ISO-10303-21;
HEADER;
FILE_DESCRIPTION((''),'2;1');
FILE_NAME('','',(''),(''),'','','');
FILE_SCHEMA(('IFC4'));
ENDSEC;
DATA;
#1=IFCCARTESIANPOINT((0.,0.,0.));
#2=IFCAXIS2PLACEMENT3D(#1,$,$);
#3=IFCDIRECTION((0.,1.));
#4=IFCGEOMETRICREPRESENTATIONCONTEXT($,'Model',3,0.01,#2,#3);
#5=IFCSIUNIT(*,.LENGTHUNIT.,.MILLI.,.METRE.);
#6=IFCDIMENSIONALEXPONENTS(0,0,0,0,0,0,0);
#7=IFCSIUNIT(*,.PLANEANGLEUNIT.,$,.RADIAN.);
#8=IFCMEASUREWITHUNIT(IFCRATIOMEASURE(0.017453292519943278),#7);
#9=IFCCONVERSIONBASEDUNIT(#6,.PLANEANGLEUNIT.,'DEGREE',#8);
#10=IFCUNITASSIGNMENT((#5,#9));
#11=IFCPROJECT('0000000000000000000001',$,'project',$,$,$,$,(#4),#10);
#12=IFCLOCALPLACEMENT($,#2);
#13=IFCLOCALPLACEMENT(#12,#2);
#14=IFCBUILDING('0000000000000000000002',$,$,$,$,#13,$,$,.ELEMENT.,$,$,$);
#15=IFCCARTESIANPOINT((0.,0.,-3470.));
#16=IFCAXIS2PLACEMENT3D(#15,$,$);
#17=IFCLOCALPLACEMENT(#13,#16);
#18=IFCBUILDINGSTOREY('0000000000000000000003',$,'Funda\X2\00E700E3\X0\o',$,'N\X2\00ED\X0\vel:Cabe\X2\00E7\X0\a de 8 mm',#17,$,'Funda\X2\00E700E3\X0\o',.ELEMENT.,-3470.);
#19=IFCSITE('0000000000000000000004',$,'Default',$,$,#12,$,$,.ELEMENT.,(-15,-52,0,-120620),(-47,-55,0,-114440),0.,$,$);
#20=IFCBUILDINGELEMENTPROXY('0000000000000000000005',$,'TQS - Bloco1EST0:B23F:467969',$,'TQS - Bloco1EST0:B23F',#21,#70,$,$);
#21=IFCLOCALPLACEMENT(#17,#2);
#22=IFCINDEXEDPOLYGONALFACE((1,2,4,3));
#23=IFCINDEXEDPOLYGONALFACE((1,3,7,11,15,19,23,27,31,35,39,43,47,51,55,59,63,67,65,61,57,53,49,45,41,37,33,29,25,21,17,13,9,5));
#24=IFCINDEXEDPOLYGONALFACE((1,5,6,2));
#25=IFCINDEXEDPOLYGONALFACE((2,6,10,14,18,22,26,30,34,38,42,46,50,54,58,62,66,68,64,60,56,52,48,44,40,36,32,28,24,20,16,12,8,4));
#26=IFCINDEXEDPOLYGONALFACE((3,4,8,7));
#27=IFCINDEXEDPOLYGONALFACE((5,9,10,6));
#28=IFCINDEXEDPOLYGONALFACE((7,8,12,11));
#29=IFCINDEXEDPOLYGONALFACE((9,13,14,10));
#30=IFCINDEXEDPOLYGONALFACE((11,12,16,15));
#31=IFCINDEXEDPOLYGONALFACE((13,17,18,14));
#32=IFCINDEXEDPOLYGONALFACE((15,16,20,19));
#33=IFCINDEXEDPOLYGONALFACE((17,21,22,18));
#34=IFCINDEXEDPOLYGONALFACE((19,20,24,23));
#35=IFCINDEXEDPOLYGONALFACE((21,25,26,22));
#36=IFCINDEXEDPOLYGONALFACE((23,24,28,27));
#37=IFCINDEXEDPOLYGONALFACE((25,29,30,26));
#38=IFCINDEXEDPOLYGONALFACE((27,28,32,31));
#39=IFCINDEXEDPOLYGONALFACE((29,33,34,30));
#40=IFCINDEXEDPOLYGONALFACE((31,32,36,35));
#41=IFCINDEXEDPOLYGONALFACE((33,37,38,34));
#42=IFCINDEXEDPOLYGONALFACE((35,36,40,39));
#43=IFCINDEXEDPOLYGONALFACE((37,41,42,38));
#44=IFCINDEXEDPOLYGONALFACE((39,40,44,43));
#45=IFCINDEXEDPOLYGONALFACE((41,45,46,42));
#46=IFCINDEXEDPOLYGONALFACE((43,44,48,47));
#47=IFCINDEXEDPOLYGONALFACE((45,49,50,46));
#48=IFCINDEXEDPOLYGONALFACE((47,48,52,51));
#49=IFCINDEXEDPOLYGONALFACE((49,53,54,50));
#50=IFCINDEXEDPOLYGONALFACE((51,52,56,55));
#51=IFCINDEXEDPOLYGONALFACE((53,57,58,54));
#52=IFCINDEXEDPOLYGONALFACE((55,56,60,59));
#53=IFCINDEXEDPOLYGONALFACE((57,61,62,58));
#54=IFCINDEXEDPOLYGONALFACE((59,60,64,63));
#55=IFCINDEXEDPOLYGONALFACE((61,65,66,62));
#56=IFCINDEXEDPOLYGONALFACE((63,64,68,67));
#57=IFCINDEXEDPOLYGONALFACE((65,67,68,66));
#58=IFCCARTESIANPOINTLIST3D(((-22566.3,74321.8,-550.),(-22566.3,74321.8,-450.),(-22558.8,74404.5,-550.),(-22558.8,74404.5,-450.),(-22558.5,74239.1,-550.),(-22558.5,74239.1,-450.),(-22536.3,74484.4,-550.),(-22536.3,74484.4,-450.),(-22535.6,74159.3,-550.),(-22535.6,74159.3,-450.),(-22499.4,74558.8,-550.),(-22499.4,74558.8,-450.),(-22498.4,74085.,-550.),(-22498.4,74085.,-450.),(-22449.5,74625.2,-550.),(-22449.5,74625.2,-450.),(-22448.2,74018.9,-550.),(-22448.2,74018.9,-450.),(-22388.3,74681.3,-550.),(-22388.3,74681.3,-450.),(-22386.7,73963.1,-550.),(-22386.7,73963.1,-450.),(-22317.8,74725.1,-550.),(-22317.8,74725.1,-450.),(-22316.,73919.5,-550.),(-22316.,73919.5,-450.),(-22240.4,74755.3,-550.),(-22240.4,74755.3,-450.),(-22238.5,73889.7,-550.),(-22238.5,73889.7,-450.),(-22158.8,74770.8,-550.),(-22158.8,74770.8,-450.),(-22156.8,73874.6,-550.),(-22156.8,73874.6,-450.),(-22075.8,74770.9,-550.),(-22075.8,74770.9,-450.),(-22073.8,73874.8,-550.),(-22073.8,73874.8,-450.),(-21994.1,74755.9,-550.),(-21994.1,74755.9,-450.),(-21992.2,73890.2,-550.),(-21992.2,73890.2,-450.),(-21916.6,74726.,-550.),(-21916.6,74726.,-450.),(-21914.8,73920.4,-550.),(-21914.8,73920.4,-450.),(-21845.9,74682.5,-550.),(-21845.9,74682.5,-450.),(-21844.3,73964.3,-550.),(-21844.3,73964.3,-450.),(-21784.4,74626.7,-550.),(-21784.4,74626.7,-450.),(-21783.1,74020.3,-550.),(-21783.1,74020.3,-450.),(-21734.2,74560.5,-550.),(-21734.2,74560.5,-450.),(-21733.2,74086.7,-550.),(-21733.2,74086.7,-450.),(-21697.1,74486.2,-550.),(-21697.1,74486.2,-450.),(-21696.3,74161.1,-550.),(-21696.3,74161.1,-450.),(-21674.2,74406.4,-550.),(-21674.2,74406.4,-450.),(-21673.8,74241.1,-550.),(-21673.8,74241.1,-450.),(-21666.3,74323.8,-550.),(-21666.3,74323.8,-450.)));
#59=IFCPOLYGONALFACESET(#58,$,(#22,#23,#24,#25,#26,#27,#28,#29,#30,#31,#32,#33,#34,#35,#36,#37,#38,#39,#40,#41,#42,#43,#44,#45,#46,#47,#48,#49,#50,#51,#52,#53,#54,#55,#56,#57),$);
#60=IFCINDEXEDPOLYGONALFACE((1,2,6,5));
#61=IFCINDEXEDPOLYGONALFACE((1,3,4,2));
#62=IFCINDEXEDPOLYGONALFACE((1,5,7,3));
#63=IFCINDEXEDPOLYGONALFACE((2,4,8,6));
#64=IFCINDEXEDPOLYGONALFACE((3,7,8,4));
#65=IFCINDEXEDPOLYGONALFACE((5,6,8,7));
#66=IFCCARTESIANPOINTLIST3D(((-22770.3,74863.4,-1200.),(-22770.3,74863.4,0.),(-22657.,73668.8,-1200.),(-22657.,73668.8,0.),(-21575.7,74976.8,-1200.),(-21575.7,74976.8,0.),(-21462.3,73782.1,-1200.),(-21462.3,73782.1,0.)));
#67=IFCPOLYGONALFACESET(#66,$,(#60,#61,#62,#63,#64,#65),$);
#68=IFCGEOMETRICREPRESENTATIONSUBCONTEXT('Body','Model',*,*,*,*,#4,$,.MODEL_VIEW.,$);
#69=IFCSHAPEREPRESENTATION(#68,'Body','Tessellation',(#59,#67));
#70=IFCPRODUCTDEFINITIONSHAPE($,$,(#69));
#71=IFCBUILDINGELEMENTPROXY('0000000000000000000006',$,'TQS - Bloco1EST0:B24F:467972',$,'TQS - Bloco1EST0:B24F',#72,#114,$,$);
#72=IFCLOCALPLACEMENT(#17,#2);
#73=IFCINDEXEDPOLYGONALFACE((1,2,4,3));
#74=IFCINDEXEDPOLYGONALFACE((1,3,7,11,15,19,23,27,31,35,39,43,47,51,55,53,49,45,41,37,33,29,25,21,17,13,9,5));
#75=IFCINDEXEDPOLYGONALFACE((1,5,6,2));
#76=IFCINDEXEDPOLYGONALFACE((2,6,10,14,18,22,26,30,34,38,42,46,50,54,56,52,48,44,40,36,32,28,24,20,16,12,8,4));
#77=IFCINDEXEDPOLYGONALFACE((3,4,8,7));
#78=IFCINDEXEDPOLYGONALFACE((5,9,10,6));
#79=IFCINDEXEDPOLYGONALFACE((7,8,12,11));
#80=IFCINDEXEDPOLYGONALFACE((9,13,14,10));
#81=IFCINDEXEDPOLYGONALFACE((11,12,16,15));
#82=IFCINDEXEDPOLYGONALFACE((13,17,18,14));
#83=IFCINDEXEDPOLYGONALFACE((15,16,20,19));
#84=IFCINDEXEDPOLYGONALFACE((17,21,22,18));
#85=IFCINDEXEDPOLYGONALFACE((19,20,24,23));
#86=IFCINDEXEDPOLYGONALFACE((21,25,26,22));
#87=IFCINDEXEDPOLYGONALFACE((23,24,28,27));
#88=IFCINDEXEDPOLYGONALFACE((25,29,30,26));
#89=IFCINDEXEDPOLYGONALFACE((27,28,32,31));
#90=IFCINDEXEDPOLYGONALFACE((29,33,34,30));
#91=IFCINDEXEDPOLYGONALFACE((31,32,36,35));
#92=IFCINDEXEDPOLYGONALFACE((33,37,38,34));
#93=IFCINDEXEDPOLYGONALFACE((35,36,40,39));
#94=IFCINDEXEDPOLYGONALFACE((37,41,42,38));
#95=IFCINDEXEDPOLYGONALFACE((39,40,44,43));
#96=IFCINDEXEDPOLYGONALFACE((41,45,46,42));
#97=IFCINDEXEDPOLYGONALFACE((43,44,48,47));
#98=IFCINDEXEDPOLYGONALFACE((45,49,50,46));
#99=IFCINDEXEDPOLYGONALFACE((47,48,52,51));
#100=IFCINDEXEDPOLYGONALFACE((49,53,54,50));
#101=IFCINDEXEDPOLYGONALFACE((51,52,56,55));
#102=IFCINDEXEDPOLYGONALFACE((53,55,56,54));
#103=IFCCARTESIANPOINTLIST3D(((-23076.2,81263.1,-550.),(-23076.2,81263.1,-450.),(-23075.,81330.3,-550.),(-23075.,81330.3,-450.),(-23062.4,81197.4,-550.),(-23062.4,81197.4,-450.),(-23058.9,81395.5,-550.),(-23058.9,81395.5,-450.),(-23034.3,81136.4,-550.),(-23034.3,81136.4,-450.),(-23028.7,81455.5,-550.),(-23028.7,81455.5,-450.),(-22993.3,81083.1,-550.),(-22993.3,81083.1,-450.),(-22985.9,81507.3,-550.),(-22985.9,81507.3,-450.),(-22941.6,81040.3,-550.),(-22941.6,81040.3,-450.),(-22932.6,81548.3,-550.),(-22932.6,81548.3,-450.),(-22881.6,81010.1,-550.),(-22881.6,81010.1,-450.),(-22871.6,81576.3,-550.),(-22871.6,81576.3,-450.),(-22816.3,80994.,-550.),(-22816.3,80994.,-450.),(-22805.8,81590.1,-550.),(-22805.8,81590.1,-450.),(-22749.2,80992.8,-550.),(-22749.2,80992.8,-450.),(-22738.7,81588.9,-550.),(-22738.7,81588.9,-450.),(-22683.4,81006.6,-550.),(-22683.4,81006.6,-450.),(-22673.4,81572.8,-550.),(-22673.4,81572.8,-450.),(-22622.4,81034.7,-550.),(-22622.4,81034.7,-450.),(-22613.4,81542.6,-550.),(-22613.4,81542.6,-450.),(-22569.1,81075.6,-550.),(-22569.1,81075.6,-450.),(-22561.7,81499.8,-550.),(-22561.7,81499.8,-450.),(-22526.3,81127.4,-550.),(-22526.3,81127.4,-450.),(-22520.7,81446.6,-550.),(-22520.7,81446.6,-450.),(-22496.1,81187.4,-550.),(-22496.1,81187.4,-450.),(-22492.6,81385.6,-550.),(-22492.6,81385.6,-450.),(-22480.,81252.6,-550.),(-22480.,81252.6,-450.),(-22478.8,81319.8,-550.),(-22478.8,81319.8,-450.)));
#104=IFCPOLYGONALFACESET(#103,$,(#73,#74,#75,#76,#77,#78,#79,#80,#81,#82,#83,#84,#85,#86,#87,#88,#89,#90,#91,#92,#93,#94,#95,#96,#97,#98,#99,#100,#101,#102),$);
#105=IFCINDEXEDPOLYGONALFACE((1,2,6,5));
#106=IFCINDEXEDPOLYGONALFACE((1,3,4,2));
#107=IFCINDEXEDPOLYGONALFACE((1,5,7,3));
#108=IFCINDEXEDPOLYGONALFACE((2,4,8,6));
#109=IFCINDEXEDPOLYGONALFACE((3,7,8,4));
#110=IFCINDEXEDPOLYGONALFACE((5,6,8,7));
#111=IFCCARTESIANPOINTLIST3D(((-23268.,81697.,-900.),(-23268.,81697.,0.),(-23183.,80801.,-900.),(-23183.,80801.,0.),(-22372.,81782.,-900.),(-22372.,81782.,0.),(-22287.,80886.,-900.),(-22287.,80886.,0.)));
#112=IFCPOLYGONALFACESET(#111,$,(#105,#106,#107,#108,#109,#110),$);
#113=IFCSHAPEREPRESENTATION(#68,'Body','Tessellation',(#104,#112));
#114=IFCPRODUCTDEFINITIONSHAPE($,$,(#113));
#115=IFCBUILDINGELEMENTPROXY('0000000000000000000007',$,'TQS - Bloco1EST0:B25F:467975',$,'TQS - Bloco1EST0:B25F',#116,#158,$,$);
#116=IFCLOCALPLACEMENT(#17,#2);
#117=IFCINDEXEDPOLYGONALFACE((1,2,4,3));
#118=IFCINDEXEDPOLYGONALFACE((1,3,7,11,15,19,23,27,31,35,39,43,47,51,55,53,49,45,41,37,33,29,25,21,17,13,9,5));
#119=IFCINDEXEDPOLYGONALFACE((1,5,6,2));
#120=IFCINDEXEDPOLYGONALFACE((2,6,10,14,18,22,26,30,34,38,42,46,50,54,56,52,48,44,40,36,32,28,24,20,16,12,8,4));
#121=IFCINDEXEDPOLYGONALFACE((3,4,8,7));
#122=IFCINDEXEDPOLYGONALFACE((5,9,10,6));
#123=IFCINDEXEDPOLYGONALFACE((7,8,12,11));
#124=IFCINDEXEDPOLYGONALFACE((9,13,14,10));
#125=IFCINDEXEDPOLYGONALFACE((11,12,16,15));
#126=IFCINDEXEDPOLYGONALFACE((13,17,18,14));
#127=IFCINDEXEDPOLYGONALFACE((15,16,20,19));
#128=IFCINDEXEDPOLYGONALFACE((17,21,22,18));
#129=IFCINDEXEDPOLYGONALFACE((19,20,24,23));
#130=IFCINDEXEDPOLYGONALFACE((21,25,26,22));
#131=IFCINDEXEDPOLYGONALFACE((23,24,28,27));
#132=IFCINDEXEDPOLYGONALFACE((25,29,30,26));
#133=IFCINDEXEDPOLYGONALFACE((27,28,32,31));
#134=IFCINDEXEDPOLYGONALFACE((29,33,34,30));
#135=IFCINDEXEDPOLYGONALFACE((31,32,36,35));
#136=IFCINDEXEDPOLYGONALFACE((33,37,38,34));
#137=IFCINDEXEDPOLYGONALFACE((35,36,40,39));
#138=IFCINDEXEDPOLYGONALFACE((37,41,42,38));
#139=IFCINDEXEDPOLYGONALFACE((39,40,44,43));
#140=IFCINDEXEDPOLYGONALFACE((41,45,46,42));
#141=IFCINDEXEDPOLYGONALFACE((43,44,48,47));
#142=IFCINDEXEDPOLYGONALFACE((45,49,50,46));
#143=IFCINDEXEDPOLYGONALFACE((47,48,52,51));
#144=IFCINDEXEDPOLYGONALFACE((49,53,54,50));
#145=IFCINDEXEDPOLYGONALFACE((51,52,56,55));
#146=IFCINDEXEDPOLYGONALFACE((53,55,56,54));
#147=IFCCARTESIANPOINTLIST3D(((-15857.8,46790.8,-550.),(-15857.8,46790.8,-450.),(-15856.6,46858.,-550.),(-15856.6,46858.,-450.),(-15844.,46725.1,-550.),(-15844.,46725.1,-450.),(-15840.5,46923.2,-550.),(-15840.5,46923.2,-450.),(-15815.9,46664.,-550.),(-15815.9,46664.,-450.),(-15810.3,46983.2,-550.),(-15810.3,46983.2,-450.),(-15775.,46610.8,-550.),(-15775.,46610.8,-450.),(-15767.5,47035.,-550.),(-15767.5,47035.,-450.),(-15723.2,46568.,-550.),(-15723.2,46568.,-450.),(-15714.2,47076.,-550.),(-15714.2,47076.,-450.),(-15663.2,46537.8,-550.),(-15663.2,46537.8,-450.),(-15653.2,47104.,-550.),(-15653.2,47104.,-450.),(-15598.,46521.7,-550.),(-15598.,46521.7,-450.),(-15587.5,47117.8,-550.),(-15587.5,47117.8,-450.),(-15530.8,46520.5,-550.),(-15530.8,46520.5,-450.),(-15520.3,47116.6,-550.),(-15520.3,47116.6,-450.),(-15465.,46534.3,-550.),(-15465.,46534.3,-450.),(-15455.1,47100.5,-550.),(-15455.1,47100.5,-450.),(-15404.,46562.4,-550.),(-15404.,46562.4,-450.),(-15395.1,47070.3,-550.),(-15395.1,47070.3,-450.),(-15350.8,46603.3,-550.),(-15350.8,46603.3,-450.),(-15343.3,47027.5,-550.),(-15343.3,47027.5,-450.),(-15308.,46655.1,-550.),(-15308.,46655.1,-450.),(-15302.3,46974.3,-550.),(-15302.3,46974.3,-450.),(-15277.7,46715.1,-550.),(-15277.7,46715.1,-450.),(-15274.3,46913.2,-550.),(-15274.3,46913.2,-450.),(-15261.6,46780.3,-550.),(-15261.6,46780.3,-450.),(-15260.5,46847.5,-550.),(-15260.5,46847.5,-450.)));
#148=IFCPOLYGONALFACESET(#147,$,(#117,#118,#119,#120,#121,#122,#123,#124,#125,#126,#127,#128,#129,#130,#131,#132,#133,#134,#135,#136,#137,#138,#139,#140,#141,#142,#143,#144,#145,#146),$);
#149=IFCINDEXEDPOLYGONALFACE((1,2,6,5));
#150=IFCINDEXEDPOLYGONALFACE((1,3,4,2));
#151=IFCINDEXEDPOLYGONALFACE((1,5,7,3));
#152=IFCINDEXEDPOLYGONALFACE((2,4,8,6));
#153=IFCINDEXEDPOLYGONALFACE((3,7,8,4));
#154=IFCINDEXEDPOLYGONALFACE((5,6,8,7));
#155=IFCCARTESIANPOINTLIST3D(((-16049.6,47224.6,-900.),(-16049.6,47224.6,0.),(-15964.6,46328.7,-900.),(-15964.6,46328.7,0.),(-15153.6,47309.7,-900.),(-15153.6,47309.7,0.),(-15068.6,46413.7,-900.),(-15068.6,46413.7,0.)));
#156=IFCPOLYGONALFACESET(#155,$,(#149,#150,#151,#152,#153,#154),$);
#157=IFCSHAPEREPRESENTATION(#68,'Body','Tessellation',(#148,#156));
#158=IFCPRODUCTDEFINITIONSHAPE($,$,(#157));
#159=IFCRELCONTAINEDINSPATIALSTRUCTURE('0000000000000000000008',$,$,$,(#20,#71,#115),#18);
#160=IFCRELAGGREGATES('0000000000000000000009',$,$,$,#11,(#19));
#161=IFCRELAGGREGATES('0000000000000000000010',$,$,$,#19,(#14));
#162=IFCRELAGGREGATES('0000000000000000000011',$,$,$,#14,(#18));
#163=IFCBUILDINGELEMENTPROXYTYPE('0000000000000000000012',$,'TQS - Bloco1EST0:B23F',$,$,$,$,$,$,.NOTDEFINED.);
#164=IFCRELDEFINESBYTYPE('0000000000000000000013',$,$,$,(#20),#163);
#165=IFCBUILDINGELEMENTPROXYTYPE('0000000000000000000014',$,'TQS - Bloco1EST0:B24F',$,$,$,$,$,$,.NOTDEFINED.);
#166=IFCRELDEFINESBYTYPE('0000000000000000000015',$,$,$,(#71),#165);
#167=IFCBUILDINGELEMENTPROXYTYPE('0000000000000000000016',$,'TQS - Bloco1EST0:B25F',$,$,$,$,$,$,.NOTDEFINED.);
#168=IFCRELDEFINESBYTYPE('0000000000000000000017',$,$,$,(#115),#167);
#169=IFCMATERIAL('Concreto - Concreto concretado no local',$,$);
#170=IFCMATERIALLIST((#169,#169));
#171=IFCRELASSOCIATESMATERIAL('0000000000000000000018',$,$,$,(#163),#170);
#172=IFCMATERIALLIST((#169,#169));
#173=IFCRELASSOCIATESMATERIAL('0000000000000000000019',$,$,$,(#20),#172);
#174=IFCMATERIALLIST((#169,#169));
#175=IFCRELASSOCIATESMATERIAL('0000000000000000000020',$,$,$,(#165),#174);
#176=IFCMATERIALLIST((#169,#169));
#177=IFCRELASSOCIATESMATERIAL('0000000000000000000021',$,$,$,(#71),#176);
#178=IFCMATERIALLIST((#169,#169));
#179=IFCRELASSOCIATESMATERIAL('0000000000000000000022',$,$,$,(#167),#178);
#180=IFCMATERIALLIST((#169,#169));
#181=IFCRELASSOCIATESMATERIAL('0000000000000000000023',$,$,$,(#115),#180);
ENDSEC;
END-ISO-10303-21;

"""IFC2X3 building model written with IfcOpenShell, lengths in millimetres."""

from ifc_helpers import new_model, entity, si_unit, converted_unit, direction, frame, frame_2d, origin, origin_2d_with_axis, place, context, subcontext, project, spatial, rectangle, circle, extrude, source, transform, mapped, material, material_list, type_object, type_shapes, element, save


model = new_model("IFC2X3")

# Units and contexts
model_context = context("Model", 3, precision=0.01, world=origin(), true_north=direction((0.0, 1.0)))
body_context = subcontext(model_context, "Body", "Model", "MODEL_VIEW")
ifc_project = project(units=[si_unit("LENGTHUNIT", "METRE", prefix="MILLI"), converted_unit("PLANEANGLEUNIT", "DEGREE", entity("IfcRatioMeasure", 0.017453292519943278), si_unit("PLANEANGLEUNIT", "RADIAN"), dimensions=[0, 0, 0, 0, 0, 0, 0])], contexts=[model_context])

# Site, building, storey
site_placement = place(None, origin())
site = spatial("IfcSite", under=ifc_project, at=site_placement, Name="Default", CompositionType="ELEMENT", RefLatitude=(-15, -52, 0, -120620), RefLongitude=(-47, -55, 0, -114440), RefElevation=0.0)
building_placement = place(site_placement, origin())
building = spatial("IfcBuilding", under=site, at=building_placement, CompositionType="ELEMENT")
storey_placement = place(building_placement, frame((0.0, 0.0, -3470.0)))
storey = spatial("IfcBuildingStorey", under=building, at=storey_placement, Name="Fundação", ObjectType="Nível:Cabeça de 8 mm", LongName="Fundação", CompositionType="ELEMENT", Elevation=-3470.0)

# Building element proxies
ifc_material_1 = material(Name="Concreto - Concreto concretado no local")
ifc_material_list_1 = material_list([ifc_material_1, ifc_material_1])
ifc_material_list_2 = material_list([ifc_material_1, ifc_material_1])
building_element_proxy_type_1 = type_object("IfcBuildingElementProxyType", Name="TQS - Bloco1EST0:B23F", PredefinedType="NOTDEFINED", material=ifc_material_list_2)
shared_shape_1 = source(origin(), body_context, "Body", "SweptSolid", [
    extrude(circle(Radius=450.0, at=frame_2d((0.0, 0.0), x_axis=(1.0, 0.0))), frame((0.0, 0.0, -550.0)), (0.0, 0.0, 1.0), 100.0),
    extrude(rectangle(XDim=1200.0, YDim=1200.0, at=origin_2d_with_axis()), frame((0.0, 0.0, -1200.0), z_axis=(0.0, 0.0, 1.0), x_axis=(-1.0, 0.0, 0.0)), (0.0, 0.0, 1.0), 1200.0),
])
type_shapes(building_element_proxy_type_1, [shared_shape_1])
proxy_1_placement = place(storey_placement, frame((-22116.3, 74322.8, 0.0), z_axis=(0.0, 0.0, 1.0), x_axis=(-0.094456, 0.995529, 0.0)))
element("IfcBuildingElementProxy", 1, at=proxy_1_placement, inside=storey, type_object=building_element_proxy_type_1, material=ifc_material_list_1, Name="TQS - Bloco1EST0:B23F:467969", ObjectType="TQS - Bloco1EST0:B23F", context=body_context, shape_type="MappedRepresentation", body=[
    mapped(shared_shape_1, transform((0.0, 0.0, 0.0), scale=1.0)),
])
ifc_material_list_3 = material_list([ifc_material_1, ifc_material_1])
ifc_material_list_4 = material_list([ifc_material_1, ifc_material_1])
building_element_proxy_type_2 = type_object("IfcBuildingElementProxyType", Name="TQS - Bloco1EST0:B24F", PredefinedType="NOTDEFINED", material=ifc_material_list_4)
shared_shape_2 = source(origin(), body_context, "Body", "SweptSolid", [
    extrude(circle(Radius=300.0, at=frame_2d((0.0, 0.0), x_axis=(1.0, 0.0))), frame((0.0, 0.0, -550.0)), (0.0, 0.0, 1.0), 100.0),
    extrude(rectangle(XDim=900.0, YDim=900.0, at=origin_2d_with_axis()), frame((0.0, 0.0, -900.0), z_axis=(0.0, 0.0, 1.0), x_axis=(-1.0, 0.0, 0.0)), (0.0, 0.0, 1.0), 900.0),
])
type_shapes(building_element_proxy_type_2, [shared_shape_2])
proxy_2_placement = place(storey_placement, frame((-22777.5, 81291.5, 0.0), z_axis=(0.0, 0.0, 1.0), x_axis=(-0.094456, 0.995529, 0.0)))
element("IfcBuildingElementProxy", 2, at=proxy_2_placement, inside=storey, type_object=building_element_proxy_type_2, material=ifc_material_list_3, Name="TQS - Bloco1EST0:B24F:467972", ObjectType="TQS - Bloco1EST0:B24F", context=body_context, shape_type="MappedRepresentation", body=[
    mapped(shared_shape_2, transform((0.0, 0.0, 0.0), scale=1.0)),
])
ifc_material_list_5 = material_list([ifc_material_1, ifc_material_1])
ifc_material_list_6 = material_list([ifc_material_1, ifc_material_1])
building_element_proxy_type_3 = type_object("IfcBuildingElementProxyType", Name="TQS - Bloco1EST0:B25F", PredefinedType="NOTDEFINED", material=ifc_material_list_6)
shared_shape_3 = source(origin(), body_context, "Body", "SweptSolid", [
    extrude(circle(Radius=300.0, at=frame_2d((0.0, 0.0), x_axis=(1.0, 0.0))), frame((0.0, 0.0, -550.0)), (0.0, 0.0, 1.0), 100.0),
    extrude(rectangle(XDim=900.0, YDim=900.0, at=origin_2d_with_axis()), frame((0.0, 0.0, -900.0), z_axis=(0.0, 0.0, 1.0), x_axis=(-1.0, 0.0, 0.0)), (0.0, 0.0, 1.0), 900.0),
])
type_shapes(building_element_proxy_type_3, [shared_shape_3])
proxy_3_placement = place(storey_placement, frame((-15559.1, 46819.2, 0.0), z_axis=(0.0, 0.0, 1.0), x_axis=(-0.094456, 0.995529, 0.0)))
element("IfcBuildingElementProxy", 3, at=proxy_3_placement, inside=storey, type_object=building_element_proxy_type_3, material=ifc_material_list_5, Name="TQS - Bloco1EST0:B25F:467975", ObjectType="TQS - Bloco1EST0:B25F", context=body_context, shape_type="MappedRepresentation", body=[
    mapped(shared_shape_3, transform((0.0, 0.0, 0.0), scale=1.0)),
])

save(model, "model.ifc")
